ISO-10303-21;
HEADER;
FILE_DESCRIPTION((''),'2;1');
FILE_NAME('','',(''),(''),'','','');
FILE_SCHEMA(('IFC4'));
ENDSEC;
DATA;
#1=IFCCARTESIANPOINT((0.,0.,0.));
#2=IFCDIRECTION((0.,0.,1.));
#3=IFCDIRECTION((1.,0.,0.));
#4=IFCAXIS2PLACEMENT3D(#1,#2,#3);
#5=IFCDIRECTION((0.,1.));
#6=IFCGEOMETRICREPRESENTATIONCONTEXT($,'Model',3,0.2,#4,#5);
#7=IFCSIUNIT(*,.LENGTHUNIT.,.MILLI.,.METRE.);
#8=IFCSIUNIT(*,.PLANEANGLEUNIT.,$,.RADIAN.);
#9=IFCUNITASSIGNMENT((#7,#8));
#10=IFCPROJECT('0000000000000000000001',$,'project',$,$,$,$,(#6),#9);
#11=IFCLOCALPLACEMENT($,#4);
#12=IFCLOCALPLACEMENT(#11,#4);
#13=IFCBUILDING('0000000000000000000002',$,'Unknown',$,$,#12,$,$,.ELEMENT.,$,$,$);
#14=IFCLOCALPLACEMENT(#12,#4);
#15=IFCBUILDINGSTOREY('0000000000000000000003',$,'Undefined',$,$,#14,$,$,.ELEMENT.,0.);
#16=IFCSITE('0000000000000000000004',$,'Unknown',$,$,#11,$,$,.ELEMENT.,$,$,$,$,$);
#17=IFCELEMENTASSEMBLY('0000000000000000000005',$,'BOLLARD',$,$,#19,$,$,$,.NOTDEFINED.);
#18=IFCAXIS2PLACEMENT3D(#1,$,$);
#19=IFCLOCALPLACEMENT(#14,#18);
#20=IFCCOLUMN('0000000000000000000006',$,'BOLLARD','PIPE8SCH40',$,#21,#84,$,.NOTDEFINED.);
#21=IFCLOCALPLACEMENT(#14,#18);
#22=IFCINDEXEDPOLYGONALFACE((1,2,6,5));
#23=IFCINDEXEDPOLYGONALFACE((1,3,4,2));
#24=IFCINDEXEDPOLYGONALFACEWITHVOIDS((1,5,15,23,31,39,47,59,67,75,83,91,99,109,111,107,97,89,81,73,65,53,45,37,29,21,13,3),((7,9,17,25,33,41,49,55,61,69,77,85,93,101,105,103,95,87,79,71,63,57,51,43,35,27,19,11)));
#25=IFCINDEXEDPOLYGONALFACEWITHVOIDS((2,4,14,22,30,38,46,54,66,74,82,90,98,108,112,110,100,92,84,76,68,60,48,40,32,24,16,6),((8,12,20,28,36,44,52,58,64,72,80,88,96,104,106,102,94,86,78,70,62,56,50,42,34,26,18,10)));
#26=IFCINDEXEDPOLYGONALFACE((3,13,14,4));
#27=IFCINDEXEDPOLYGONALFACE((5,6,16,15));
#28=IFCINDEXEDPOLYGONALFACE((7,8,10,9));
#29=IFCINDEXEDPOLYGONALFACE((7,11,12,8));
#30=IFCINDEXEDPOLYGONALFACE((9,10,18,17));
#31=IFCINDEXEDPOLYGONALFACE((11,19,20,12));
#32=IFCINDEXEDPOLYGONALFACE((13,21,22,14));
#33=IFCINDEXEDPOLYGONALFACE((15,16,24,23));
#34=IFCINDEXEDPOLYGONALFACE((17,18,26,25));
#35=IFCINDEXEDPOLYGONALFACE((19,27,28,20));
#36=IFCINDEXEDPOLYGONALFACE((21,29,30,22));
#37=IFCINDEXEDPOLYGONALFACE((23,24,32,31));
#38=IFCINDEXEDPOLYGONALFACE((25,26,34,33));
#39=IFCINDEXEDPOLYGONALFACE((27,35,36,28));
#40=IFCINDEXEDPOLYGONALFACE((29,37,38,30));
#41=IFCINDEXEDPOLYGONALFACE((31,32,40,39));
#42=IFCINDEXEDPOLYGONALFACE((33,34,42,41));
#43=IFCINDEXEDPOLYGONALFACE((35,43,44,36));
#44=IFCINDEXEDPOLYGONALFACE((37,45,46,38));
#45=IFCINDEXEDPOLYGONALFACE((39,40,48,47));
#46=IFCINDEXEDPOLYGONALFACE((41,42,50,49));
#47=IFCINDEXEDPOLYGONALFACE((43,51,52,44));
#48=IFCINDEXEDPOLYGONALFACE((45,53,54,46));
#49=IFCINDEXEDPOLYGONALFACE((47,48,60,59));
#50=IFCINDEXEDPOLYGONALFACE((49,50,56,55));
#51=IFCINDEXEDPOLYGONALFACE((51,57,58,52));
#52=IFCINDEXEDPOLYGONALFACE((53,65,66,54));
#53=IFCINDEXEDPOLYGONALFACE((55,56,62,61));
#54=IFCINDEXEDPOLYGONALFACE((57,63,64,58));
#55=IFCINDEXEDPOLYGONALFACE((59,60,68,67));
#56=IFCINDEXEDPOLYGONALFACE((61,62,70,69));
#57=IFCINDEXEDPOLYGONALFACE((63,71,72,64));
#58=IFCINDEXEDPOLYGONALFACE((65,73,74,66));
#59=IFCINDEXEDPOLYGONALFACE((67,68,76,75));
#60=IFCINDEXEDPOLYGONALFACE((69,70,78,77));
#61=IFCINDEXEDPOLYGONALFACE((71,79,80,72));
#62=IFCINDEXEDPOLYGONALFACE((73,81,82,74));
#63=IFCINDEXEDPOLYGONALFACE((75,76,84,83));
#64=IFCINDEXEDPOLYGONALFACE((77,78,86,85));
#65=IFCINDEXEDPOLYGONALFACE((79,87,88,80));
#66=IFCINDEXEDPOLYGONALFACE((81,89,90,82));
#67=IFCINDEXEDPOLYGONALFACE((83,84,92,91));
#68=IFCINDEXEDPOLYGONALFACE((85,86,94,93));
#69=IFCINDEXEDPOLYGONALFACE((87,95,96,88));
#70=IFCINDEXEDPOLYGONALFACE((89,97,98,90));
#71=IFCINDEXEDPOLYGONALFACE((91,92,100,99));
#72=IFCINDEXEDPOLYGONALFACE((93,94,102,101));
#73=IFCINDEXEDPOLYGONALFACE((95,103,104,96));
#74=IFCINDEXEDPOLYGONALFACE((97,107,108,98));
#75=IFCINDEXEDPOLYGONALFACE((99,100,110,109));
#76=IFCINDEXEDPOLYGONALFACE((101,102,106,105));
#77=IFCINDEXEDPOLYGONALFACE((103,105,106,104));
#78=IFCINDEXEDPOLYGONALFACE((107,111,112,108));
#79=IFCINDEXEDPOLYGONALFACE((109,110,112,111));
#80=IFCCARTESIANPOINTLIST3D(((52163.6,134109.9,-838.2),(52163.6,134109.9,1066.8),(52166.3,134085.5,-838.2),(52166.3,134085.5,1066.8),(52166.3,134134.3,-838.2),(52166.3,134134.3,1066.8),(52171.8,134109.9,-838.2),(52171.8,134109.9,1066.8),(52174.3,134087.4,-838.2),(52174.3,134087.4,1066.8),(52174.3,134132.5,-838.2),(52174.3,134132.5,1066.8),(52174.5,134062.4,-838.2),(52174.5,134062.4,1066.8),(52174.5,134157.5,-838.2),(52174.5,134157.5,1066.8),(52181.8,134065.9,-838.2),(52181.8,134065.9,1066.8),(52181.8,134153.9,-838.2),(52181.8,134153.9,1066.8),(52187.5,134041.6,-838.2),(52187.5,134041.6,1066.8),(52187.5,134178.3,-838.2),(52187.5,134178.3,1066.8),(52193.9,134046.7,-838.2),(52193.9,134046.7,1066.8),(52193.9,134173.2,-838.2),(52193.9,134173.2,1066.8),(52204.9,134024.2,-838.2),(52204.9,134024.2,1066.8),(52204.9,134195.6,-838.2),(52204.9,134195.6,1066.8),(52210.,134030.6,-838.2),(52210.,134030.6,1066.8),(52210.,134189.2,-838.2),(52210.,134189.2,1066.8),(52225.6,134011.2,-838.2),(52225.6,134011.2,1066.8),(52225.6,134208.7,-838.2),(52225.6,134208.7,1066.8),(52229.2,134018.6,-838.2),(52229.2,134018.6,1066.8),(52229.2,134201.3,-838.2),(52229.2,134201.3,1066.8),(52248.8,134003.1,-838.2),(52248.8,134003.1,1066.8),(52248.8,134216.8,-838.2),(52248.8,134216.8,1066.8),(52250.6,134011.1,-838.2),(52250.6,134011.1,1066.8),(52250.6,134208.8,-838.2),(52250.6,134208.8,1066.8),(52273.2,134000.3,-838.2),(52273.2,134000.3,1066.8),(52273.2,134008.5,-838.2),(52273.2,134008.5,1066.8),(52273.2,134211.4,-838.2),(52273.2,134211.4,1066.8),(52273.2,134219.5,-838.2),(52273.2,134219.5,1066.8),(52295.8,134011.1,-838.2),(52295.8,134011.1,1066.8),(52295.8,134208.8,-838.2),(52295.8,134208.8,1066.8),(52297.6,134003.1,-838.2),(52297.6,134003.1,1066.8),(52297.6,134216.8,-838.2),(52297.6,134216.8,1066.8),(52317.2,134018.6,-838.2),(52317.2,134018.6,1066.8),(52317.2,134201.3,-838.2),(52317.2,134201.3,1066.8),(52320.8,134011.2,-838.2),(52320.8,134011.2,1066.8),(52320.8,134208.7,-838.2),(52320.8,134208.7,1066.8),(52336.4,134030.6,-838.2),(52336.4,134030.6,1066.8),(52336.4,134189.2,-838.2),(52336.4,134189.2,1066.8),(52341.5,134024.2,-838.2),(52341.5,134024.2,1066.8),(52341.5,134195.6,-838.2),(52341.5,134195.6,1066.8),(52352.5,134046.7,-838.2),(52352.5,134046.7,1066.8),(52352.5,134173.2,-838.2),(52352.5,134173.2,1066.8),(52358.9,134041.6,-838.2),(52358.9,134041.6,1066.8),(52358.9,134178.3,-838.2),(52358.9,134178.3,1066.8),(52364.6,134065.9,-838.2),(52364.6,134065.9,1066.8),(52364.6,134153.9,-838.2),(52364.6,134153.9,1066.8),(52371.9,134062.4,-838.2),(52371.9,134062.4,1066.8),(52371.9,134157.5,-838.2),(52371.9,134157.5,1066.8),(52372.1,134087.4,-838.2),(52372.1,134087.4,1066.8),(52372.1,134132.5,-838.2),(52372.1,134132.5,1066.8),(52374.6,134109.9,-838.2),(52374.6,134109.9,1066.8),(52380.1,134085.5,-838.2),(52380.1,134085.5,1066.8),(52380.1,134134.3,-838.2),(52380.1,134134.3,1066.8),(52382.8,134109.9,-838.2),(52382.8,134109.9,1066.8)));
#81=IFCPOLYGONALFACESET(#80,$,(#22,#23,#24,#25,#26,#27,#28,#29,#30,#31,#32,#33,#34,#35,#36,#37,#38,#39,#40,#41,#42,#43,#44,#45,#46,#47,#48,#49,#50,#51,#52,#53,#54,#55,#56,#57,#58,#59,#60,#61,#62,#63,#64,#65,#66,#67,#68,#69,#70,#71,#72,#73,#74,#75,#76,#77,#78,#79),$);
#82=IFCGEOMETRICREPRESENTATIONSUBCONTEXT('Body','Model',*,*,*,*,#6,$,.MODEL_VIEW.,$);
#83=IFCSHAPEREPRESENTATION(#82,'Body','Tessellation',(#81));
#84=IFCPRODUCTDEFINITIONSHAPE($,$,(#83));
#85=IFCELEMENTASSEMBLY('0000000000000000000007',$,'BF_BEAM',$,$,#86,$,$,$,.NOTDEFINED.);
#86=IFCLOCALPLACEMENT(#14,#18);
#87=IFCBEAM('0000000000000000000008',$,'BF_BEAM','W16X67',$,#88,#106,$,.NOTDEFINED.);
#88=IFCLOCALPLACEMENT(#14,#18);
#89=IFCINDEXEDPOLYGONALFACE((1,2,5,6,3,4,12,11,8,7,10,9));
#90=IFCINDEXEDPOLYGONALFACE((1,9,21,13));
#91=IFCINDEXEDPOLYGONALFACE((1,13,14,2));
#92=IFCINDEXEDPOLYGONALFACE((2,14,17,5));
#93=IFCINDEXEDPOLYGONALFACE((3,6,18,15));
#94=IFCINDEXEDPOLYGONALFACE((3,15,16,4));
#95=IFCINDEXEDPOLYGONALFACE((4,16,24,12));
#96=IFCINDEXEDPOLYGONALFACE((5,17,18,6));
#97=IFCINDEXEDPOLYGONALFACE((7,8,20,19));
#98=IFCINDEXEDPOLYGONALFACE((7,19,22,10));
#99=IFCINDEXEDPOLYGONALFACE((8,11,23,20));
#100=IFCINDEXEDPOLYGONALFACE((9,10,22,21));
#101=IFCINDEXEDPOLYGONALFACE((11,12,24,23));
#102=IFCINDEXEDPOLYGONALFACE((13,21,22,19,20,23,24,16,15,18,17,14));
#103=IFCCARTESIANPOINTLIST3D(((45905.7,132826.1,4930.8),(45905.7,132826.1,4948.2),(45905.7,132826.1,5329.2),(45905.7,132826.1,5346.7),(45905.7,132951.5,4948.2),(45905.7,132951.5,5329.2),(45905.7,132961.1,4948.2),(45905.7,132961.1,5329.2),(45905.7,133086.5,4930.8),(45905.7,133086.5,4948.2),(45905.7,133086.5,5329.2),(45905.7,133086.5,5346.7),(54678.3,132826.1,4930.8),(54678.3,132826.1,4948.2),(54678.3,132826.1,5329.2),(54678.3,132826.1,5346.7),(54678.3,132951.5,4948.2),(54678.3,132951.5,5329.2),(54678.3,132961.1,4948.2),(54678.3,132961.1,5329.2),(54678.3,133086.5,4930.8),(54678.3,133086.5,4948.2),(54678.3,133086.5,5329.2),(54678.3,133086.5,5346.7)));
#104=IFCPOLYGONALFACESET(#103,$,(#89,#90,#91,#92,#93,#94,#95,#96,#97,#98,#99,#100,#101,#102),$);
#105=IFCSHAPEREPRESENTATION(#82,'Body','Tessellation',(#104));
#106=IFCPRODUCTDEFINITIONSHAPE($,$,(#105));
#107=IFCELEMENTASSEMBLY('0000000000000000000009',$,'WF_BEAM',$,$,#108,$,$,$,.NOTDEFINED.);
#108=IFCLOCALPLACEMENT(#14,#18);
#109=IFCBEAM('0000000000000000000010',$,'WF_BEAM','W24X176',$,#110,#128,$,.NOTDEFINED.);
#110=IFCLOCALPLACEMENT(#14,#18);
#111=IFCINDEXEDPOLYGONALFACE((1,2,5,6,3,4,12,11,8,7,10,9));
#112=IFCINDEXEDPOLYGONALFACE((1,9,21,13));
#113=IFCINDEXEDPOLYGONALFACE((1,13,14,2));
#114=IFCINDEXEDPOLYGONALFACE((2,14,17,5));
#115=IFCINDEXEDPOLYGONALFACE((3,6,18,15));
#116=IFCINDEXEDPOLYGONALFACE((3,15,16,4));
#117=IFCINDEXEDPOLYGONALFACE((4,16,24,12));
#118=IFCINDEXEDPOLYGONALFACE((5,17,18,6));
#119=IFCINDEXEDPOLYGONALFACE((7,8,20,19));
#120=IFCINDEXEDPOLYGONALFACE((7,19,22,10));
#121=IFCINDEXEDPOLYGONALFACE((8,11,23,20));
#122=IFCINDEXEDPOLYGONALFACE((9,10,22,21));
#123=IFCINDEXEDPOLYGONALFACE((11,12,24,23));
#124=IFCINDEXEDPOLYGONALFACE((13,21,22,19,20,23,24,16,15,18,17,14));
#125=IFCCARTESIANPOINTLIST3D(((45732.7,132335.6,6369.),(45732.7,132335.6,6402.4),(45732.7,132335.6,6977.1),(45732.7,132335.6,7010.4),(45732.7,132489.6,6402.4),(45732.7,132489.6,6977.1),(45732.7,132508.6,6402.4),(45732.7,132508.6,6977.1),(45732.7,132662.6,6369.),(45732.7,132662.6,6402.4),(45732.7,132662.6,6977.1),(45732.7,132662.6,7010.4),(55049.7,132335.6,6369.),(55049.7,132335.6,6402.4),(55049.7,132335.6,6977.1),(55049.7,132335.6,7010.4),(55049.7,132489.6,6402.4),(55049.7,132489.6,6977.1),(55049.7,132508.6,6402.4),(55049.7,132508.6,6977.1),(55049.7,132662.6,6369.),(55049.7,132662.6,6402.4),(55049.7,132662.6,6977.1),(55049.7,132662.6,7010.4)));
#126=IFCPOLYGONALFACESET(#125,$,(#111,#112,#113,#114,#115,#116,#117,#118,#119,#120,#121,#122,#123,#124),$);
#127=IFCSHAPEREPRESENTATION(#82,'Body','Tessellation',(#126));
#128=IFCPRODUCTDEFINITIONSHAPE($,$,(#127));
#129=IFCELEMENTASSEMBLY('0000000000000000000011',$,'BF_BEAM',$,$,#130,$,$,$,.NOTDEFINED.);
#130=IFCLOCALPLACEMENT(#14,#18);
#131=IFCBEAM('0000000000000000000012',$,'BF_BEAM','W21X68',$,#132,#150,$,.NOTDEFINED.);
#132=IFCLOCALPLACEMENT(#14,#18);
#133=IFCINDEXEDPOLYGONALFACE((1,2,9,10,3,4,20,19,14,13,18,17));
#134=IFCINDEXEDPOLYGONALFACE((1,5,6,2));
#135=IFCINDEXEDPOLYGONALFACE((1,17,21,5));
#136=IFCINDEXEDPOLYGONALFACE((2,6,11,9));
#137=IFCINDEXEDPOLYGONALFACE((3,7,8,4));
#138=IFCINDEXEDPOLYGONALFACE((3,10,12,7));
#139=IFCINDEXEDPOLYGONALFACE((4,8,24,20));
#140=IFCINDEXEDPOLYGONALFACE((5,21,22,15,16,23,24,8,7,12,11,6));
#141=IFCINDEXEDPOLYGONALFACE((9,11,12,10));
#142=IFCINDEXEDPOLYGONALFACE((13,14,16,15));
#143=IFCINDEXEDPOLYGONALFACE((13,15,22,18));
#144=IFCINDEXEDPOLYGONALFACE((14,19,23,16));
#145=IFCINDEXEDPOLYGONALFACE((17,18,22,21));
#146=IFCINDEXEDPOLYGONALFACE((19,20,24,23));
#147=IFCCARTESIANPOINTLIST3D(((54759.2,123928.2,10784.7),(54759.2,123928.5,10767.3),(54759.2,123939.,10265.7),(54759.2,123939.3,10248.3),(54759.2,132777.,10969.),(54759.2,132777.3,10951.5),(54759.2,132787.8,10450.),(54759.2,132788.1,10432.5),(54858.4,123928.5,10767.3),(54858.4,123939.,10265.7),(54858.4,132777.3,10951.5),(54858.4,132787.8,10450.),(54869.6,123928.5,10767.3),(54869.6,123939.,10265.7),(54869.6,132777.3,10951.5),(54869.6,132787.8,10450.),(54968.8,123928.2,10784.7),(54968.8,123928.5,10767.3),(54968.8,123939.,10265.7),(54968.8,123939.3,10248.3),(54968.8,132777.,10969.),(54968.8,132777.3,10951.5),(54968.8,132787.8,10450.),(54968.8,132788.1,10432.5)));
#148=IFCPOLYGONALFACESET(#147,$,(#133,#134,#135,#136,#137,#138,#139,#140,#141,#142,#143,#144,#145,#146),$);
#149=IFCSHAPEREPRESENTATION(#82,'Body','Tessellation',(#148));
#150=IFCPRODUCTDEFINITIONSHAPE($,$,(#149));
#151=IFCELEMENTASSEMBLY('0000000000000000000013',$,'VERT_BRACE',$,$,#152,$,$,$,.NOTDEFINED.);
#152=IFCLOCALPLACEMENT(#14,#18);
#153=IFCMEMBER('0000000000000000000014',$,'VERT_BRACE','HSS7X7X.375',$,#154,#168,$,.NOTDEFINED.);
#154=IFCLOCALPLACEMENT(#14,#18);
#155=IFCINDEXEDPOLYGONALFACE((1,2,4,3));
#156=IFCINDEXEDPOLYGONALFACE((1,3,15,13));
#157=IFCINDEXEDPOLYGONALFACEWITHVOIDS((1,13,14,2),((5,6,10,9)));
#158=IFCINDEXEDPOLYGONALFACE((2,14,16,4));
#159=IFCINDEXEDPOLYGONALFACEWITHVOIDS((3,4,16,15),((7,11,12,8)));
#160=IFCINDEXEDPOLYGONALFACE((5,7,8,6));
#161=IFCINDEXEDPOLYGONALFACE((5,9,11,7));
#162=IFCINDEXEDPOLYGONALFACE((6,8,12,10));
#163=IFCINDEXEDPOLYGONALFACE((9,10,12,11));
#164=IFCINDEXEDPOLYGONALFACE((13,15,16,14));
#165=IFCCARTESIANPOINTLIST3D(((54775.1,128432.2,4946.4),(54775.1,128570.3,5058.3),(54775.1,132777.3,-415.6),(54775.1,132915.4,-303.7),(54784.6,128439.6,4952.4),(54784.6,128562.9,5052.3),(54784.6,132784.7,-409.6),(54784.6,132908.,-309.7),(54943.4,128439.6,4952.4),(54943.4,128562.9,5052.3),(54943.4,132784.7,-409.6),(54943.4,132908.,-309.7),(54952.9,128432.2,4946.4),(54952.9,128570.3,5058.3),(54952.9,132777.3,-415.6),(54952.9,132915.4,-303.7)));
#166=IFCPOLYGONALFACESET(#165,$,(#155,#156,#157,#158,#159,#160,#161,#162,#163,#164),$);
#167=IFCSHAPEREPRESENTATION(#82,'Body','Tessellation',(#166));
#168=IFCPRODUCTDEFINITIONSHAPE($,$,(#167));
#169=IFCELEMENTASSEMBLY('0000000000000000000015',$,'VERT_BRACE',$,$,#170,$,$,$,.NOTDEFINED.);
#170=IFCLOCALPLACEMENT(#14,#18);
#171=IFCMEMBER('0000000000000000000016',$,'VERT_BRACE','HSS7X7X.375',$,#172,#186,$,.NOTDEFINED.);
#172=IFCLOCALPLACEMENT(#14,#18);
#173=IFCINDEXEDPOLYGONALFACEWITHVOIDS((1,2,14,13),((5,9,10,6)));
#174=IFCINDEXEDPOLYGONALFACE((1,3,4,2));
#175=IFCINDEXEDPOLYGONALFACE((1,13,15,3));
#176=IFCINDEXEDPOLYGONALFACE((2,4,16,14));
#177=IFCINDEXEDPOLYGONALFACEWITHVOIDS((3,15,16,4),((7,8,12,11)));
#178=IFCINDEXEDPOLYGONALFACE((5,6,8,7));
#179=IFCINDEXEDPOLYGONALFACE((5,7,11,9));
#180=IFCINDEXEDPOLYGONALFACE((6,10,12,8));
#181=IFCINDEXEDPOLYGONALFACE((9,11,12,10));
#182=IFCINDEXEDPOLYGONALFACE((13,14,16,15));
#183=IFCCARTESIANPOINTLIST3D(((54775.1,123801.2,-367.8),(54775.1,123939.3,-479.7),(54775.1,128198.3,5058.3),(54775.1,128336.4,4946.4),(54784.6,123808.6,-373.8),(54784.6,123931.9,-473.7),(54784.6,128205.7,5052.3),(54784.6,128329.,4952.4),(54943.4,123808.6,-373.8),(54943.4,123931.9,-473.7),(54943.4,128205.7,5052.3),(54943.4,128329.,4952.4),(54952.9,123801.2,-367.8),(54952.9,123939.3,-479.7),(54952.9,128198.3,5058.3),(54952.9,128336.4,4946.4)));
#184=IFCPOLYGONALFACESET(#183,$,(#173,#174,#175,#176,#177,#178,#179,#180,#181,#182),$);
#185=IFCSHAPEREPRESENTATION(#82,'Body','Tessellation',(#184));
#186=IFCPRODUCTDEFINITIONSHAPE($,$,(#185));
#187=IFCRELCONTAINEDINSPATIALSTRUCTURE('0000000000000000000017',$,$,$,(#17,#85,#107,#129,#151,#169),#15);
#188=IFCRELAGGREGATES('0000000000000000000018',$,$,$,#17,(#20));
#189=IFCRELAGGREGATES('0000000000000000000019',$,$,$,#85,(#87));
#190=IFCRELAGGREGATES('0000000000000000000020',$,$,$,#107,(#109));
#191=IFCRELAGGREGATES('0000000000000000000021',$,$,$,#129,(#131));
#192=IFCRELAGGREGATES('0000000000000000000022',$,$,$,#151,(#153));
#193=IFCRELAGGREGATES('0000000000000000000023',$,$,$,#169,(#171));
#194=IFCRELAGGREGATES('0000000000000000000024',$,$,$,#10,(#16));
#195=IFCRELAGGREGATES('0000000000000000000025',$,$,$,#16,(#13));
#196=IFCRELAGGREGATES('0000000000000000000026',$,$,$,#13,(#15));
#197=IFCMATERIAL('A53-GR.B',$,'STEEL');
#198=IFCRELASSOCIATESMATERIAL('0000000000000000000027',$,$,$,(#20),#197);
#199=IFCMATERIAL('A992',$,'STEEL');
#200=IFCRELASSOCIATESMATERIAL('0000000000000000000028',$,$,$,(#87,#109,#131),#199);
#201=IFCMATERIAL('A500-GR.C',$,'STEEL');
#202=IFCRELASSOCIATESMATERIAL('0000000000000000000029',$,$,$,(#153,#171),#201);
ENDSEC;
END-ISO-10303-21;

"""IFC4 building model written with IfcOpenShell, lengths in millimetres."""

from ifc_helpers import new_model, si_unit, direction, frame, origin_with_axes, place, context, subcontext, project, spatial, line, indexed_curve, outline, extrude, material, element, aggregate, save


model = new_model("IFC4")

# Units and contexts
model_context = context("Model", 3, precision=0.2, world=origin_with_axes(), true_north=direction((0.0, 1.0)))
body_context = subcontext(model_context, "Body", "Model", "MODEL_VIEW")
ifc_project = project(units=[si_unit("LENGTHUNIT", "METRE", prefix="MILLI"), si_unit("PLANEANGLEUNIT", "RADIAN")], contexts=[model_context])

# Site, building, storey
site_placement = place(None, origin_with_axes())
site = spatial("IfcSite", under=ifc_project, at=site_placement, Name="Unknown", CompositionType="ELEMENT")
building_placement = place(site_placement, origin_with_axes())
building = spatial("IfcBuilding", under=site, at=building_placement, Name="Unknown", CompositionType="ELEMENT")
storey_placement = place(building_placement, origin_with_axes())
storey = spatial("IfcBuildingStorey", under=building, at=storey_placement, Name="Undefined", CompositionType="ELEMENT", Elevation=0.0)

# Element assembly, column
ifc_material_1 = material(Name="A992", Category="STEEL")
ifc_material_2 = material(Name="A53-GR.B", Category="STEEL")
assembly_1_placement = place(storey_placement, frame((52273.2, 134109.9, -838.2), z_axis=(-1.0, 0.0, 0.0), x_axis=(0.0, 0.0, 1.0)))
assembly_1 = element("IfcElementAssembly", 1, at=assembly_1_placement, inside=storey, Name="BOLLARD", PredefinedType="NOTDEFINED")
column_1_placement = place(assembly_1_placement, origin_with_axes())
column_1 = element("IfcColumn", 2, at=column_1_placement, material=ifc_material_2, Name="BOLLARD", Description="PIPE8SCH40", PredefinedType="NOTDEFINED", context=body_context, shape_type="SolidModel", body=[
    extrude(outline(indexed_curve([(109.6, 0.0), (106.9, 24.4), (98.7, 47.6), (85.7, 68.3), (68.3, 85.7), (47.6, 98.7), (24.4, 106.9), (0.0, 109.6), (-24.4, 106.9), (-47.6, 98.7), (-68.3, 85.7), (-85.7, 68.3), (-98.7, 47.6), (-106.9, 24.4), (-109.6, 0.0), (-106.9, -24.4), (-98.7, -47.6), (-85.7, -68.3), (-68.3, -85.7), (-47.6, -98.7), (-24.4, -106.9), (0.0, -109.6), (24.4, -106.9), (47.6, -98.7), (68.3, -85.7), (85.7, -68.3), (98.7, -47.6), (106.9, -24.4)], segments=[line(1, 2, 3, 4, 5, 6, 7, 8, 9, 10, 11, 12, 13, 14, 15, 16, 17, 18, 19, 20, 21, 22, 23, 24, 25, 26, 27, 28, 1)]), holes=[indexed_curve([(101.4, 0.0), (98.9, -22.6), (91.4, -44.0), (79.3, -63.2), (63.2, -79.3), (44.0, -91.4), (22.6, -98.9), (0.0, -101.4), (-22.6, -98.9), (-44.0, -91.4), (-63.2, -79.3), (-79.3, -63.2), (-91.4, -44.0), (-98.9, -22.6), (-101.4, 0.0), (-98.9, 22.6), (-91.4, 44.0), (-79.3, 63.2), (-63.2, 79.3), (-44.0, 91.4), (-22.6, 98.9), (0.0, 101.4), (22.6, 98.9), (44.0, 91.4), (63.2, 79.3), (79.3, 63.2), (91.4, 44.0), (98.9, 22.6)], segments=[line(1, 2, 3, 4, 5, 6, 7, 8, 9, 10, 11, 12, 13, 14, 15, 16, 17, 18, 19, 20, 21, 22, 23, 24, 25, 26, 27, 28, 1)])]), frame((0.0, 0.0, 0.0), z_axis=(-1.0, 0.0, 0.0), x_axis=(0.0, 0.0, 1.0)), (0.0, 0.0, -1.0), 1905.0),
])
aggregate(assembly_1, [column_1])

# Element assemblies, beams
assembly_2_placement = place(storey_placement, frame((45905.7, 132956.3, 5138.7), z_axis=(0.0, -1.0, 0.0), x_axis=(1.0, 0.0, 0.0)))
assembly_2 = element("IfcElementAssembly", 3, at=assembly_2_placement, inside=storey, Name="BF_BEAM", PredefinedType="NOTDEFINED")
beam_1_placement = place(assembly_2_placement, origin_with_axes())
beam_1 = element("IfcBeam", 4, at=beam_1_placement, material=ifc_material_1, Name="BF_BEAM", Description="W16X67", PredefinedType="NOTDEFINED", context=body_context, shape_type="SolidModel", body=[
    extrude(outline(indexed_curve([(-130.2, -208.0), (130.2, -208.0), (130.2, -190.5), (4.8, -190.5), (4.8, 190.5), (130.2, 190.5), (130.2, 208.0), (-130.2, 208.0), (-130.2, 190.5), (-4.8, 190.5), (-4.8, -190.5), (-130.2, -190.5)], segments=[line(1, 2, 3, 4, 5, 6, 7, 8, 9, 10, 11, 12, 1)])), frame((0.0, 0.0, 0.0), z_axis=(-1.0, 0.0, 0.0), x_axis=(0.0, 0.0, 1.0)), (0.0, 0.0, -1.0), 8772.5),
])
aggregate(assembly_2, [beam_1])
assembly_3_placement = place(storey_placement, frame((45732.7, 132499.1, 6689.7), z_axis=(0.0, -1.0, 0.0), x_axis=(1.0, 0.0, 0.0)))
assembly_3 = element("IfcElementAssembly", 5, at=assembly_3_placement, inside=storey, Name="WF_BEAM", PredefinedType="NOTDEFINED")
beam_2_placement = place(assembly_3_placement, origin_with_axes())
beam_2 = element("IfcBeam", 6, at=beam_2_placement, material=ifc_material_1, Name="WF_BEAM", Description="W24X176", PredefinedType="NOTDEFINED", context=body_context, shape_type="SolidModel", body=[
    extrude(outline(indexed_curve([(-163.5, -320.7), (163.5, -320.7), (163.5, -287.3), (9.5, -287.3), (9.5, 287.3), (163.5, 287.3), (163.5, 320.7), (-163.5, 320.7), (-163.5, 287.3), (-9.5, 287.3), (-9.5, -287.3), (-163.5, -287.3)], segments=[line(1, 2, 3, 4, 5, 6, 7, 8, 9, 10, 11, 12, 1)])), frame((0.0, 0.0, 0.0), z_axis=(-1.0, 0.0, 0.0), x_axis=(0.0, 0.0, 1.0)), (0.0, 0.0, -1.0), 9317.0),
])
aggregate(assembly_3, [beam_2])
assembly_4_placement = place(storey_placement, frame((54864.0, 123933.7, 10516.5), z_axis=(1.0, 0.0, 0.0), x_axis=(0.0, 0.999783, 0.020819)))
assembly_4 = element("IfcElementAssembly", 7, at=assembly_4_placement, inside=storey, Name="BF_BEAM", PredefinedType="NOTDEFINED")
beam_3_placement = place(assembly_4_placement, origin_with_axes())
beam_3 = element("IfcBeam", 8, at=beam_3_placement, material=ifc_material_1, Name="BF_BEAM", Description="W21X68", PredefinedType="NOTDEFINED", context=body_context, shape_type="SolidModel", body=[
    extrude(outline(indexed_curve([(-104.8, -268.3), (104.8, -268.3), (104.8, -250.8), (5.6, -250.8), (5.6, 250.8), (104.8, 250.8), (104.8, 268.3), (-104.8, 268.3), (-104.8, 250.8), (-5.6, 250.8), (-5.6, -250.8), (-104.8, -250.8)], segments=[line(1, 2, 3, 4, 5, 6, 7, 8, 9, 10, 11, 12, 1)])), frame((0.0, 0.0, 0.0), z_axis=(-1.0, 0.0, 0.0), x_axis=(0.0, 0.0, 1.0)), (0.0, 0.0, -1.0), 8850.7),
])
aggregate(assembly_4, [beam_3])

# Element assemblies, members
assembly_5_placement = place(storey_placement, frame((54864.0, 132846.4, -359.6), z_axis=(-1.0, 0.0, 0.0), x_axis=(0.0, -0.629588, 0.776929)))
assembly_5 = element("IfcElementAssembly", 9, at=assembly_5_placement, inside=storey, Name="VERT_BRACE", PredefinedType="NOTDEFINED")
ifc_material_3 = material(Name="A500-GR.C", Category="STEEL")
member_1_placement = place(assembly_5_placement, origin_with_axes())
member_1 = element("IfcMember", 10, at=member_1_placement, material=ifc_material_3, Name="VERT_BRACE", Description="HSS7X7X.375", PredefinedType="NOTDEFINED", context=body_context, shape_type="SolidModel", body=[
    extrude(outline(indexed_curve([(-88.9, -88.9), (88.9, -88.9), (88.9, 88.9), (-88.9, 88.9)], segments=[line(1, 2, 3, 4, 1)]), holes=[indexed_curve([(-79.4, -79.4), (-79.4, 79.4), (79.4, 79.4), (79.4, -79.4)], segments=[line(1, 2, 3, 4, 1)])]), frame((0.0, 0.0, 0.0), z_axis=(-1.0, 0.0, 0.0), x_axis=(0.0, 0.0, 1.0)), (0.0, 0.0, -1.0), 6901.5),
])
aggregate(assembly_5, [member_1])
assembly_6_placement = place(storey_placement, frame((54864.0, 123870.3, -423.8), z_axis=(1.0, 0.0, 0.0), x_axis=(0.0, 0.629588, 0.776929)))
assembly_6 = element("IfcElementAssembly", 11, at=assembly_6_placement, inside=storey, Name="VERT_BRACE", PredefinedType="NOTDEFINED")
member_2_placement = place(assembly_6_placement, origin_with_axes())
member_2 = element("IfcMember", 12, at=member_2_placement, material=ifc_material_3, Name="VERT_BRACE", Description="HSS7X7X.375", PredefinedType="NOTDEFINED", context=body_context, shape_type="SolidModel", body=[
    extrude(outline(indexed_curve([(-88.9, -88.9), (88.9, -88.9), (88.9, 88.9), (-88.9, 88.9)], segments=[line(1, 2, 3, 4, 1)]), holes=[indexed_curve([(-79.4, -79.4), (-79.4, 79.4), (79.4, 79.4), (79.4, -79.4)], segments=[line(1, 2, 3, 4, 1)])]), frame((0.0, 0.0, 0.0), z_axis=(-1.0, 0.0, 0.0), x_axis=(0.0, 0.0, 1.0)), (0.0, 0.0, -1.0), 6984.1),
])
aggregate(assembly_6, [member_2])

save(model, "model.ifc")
